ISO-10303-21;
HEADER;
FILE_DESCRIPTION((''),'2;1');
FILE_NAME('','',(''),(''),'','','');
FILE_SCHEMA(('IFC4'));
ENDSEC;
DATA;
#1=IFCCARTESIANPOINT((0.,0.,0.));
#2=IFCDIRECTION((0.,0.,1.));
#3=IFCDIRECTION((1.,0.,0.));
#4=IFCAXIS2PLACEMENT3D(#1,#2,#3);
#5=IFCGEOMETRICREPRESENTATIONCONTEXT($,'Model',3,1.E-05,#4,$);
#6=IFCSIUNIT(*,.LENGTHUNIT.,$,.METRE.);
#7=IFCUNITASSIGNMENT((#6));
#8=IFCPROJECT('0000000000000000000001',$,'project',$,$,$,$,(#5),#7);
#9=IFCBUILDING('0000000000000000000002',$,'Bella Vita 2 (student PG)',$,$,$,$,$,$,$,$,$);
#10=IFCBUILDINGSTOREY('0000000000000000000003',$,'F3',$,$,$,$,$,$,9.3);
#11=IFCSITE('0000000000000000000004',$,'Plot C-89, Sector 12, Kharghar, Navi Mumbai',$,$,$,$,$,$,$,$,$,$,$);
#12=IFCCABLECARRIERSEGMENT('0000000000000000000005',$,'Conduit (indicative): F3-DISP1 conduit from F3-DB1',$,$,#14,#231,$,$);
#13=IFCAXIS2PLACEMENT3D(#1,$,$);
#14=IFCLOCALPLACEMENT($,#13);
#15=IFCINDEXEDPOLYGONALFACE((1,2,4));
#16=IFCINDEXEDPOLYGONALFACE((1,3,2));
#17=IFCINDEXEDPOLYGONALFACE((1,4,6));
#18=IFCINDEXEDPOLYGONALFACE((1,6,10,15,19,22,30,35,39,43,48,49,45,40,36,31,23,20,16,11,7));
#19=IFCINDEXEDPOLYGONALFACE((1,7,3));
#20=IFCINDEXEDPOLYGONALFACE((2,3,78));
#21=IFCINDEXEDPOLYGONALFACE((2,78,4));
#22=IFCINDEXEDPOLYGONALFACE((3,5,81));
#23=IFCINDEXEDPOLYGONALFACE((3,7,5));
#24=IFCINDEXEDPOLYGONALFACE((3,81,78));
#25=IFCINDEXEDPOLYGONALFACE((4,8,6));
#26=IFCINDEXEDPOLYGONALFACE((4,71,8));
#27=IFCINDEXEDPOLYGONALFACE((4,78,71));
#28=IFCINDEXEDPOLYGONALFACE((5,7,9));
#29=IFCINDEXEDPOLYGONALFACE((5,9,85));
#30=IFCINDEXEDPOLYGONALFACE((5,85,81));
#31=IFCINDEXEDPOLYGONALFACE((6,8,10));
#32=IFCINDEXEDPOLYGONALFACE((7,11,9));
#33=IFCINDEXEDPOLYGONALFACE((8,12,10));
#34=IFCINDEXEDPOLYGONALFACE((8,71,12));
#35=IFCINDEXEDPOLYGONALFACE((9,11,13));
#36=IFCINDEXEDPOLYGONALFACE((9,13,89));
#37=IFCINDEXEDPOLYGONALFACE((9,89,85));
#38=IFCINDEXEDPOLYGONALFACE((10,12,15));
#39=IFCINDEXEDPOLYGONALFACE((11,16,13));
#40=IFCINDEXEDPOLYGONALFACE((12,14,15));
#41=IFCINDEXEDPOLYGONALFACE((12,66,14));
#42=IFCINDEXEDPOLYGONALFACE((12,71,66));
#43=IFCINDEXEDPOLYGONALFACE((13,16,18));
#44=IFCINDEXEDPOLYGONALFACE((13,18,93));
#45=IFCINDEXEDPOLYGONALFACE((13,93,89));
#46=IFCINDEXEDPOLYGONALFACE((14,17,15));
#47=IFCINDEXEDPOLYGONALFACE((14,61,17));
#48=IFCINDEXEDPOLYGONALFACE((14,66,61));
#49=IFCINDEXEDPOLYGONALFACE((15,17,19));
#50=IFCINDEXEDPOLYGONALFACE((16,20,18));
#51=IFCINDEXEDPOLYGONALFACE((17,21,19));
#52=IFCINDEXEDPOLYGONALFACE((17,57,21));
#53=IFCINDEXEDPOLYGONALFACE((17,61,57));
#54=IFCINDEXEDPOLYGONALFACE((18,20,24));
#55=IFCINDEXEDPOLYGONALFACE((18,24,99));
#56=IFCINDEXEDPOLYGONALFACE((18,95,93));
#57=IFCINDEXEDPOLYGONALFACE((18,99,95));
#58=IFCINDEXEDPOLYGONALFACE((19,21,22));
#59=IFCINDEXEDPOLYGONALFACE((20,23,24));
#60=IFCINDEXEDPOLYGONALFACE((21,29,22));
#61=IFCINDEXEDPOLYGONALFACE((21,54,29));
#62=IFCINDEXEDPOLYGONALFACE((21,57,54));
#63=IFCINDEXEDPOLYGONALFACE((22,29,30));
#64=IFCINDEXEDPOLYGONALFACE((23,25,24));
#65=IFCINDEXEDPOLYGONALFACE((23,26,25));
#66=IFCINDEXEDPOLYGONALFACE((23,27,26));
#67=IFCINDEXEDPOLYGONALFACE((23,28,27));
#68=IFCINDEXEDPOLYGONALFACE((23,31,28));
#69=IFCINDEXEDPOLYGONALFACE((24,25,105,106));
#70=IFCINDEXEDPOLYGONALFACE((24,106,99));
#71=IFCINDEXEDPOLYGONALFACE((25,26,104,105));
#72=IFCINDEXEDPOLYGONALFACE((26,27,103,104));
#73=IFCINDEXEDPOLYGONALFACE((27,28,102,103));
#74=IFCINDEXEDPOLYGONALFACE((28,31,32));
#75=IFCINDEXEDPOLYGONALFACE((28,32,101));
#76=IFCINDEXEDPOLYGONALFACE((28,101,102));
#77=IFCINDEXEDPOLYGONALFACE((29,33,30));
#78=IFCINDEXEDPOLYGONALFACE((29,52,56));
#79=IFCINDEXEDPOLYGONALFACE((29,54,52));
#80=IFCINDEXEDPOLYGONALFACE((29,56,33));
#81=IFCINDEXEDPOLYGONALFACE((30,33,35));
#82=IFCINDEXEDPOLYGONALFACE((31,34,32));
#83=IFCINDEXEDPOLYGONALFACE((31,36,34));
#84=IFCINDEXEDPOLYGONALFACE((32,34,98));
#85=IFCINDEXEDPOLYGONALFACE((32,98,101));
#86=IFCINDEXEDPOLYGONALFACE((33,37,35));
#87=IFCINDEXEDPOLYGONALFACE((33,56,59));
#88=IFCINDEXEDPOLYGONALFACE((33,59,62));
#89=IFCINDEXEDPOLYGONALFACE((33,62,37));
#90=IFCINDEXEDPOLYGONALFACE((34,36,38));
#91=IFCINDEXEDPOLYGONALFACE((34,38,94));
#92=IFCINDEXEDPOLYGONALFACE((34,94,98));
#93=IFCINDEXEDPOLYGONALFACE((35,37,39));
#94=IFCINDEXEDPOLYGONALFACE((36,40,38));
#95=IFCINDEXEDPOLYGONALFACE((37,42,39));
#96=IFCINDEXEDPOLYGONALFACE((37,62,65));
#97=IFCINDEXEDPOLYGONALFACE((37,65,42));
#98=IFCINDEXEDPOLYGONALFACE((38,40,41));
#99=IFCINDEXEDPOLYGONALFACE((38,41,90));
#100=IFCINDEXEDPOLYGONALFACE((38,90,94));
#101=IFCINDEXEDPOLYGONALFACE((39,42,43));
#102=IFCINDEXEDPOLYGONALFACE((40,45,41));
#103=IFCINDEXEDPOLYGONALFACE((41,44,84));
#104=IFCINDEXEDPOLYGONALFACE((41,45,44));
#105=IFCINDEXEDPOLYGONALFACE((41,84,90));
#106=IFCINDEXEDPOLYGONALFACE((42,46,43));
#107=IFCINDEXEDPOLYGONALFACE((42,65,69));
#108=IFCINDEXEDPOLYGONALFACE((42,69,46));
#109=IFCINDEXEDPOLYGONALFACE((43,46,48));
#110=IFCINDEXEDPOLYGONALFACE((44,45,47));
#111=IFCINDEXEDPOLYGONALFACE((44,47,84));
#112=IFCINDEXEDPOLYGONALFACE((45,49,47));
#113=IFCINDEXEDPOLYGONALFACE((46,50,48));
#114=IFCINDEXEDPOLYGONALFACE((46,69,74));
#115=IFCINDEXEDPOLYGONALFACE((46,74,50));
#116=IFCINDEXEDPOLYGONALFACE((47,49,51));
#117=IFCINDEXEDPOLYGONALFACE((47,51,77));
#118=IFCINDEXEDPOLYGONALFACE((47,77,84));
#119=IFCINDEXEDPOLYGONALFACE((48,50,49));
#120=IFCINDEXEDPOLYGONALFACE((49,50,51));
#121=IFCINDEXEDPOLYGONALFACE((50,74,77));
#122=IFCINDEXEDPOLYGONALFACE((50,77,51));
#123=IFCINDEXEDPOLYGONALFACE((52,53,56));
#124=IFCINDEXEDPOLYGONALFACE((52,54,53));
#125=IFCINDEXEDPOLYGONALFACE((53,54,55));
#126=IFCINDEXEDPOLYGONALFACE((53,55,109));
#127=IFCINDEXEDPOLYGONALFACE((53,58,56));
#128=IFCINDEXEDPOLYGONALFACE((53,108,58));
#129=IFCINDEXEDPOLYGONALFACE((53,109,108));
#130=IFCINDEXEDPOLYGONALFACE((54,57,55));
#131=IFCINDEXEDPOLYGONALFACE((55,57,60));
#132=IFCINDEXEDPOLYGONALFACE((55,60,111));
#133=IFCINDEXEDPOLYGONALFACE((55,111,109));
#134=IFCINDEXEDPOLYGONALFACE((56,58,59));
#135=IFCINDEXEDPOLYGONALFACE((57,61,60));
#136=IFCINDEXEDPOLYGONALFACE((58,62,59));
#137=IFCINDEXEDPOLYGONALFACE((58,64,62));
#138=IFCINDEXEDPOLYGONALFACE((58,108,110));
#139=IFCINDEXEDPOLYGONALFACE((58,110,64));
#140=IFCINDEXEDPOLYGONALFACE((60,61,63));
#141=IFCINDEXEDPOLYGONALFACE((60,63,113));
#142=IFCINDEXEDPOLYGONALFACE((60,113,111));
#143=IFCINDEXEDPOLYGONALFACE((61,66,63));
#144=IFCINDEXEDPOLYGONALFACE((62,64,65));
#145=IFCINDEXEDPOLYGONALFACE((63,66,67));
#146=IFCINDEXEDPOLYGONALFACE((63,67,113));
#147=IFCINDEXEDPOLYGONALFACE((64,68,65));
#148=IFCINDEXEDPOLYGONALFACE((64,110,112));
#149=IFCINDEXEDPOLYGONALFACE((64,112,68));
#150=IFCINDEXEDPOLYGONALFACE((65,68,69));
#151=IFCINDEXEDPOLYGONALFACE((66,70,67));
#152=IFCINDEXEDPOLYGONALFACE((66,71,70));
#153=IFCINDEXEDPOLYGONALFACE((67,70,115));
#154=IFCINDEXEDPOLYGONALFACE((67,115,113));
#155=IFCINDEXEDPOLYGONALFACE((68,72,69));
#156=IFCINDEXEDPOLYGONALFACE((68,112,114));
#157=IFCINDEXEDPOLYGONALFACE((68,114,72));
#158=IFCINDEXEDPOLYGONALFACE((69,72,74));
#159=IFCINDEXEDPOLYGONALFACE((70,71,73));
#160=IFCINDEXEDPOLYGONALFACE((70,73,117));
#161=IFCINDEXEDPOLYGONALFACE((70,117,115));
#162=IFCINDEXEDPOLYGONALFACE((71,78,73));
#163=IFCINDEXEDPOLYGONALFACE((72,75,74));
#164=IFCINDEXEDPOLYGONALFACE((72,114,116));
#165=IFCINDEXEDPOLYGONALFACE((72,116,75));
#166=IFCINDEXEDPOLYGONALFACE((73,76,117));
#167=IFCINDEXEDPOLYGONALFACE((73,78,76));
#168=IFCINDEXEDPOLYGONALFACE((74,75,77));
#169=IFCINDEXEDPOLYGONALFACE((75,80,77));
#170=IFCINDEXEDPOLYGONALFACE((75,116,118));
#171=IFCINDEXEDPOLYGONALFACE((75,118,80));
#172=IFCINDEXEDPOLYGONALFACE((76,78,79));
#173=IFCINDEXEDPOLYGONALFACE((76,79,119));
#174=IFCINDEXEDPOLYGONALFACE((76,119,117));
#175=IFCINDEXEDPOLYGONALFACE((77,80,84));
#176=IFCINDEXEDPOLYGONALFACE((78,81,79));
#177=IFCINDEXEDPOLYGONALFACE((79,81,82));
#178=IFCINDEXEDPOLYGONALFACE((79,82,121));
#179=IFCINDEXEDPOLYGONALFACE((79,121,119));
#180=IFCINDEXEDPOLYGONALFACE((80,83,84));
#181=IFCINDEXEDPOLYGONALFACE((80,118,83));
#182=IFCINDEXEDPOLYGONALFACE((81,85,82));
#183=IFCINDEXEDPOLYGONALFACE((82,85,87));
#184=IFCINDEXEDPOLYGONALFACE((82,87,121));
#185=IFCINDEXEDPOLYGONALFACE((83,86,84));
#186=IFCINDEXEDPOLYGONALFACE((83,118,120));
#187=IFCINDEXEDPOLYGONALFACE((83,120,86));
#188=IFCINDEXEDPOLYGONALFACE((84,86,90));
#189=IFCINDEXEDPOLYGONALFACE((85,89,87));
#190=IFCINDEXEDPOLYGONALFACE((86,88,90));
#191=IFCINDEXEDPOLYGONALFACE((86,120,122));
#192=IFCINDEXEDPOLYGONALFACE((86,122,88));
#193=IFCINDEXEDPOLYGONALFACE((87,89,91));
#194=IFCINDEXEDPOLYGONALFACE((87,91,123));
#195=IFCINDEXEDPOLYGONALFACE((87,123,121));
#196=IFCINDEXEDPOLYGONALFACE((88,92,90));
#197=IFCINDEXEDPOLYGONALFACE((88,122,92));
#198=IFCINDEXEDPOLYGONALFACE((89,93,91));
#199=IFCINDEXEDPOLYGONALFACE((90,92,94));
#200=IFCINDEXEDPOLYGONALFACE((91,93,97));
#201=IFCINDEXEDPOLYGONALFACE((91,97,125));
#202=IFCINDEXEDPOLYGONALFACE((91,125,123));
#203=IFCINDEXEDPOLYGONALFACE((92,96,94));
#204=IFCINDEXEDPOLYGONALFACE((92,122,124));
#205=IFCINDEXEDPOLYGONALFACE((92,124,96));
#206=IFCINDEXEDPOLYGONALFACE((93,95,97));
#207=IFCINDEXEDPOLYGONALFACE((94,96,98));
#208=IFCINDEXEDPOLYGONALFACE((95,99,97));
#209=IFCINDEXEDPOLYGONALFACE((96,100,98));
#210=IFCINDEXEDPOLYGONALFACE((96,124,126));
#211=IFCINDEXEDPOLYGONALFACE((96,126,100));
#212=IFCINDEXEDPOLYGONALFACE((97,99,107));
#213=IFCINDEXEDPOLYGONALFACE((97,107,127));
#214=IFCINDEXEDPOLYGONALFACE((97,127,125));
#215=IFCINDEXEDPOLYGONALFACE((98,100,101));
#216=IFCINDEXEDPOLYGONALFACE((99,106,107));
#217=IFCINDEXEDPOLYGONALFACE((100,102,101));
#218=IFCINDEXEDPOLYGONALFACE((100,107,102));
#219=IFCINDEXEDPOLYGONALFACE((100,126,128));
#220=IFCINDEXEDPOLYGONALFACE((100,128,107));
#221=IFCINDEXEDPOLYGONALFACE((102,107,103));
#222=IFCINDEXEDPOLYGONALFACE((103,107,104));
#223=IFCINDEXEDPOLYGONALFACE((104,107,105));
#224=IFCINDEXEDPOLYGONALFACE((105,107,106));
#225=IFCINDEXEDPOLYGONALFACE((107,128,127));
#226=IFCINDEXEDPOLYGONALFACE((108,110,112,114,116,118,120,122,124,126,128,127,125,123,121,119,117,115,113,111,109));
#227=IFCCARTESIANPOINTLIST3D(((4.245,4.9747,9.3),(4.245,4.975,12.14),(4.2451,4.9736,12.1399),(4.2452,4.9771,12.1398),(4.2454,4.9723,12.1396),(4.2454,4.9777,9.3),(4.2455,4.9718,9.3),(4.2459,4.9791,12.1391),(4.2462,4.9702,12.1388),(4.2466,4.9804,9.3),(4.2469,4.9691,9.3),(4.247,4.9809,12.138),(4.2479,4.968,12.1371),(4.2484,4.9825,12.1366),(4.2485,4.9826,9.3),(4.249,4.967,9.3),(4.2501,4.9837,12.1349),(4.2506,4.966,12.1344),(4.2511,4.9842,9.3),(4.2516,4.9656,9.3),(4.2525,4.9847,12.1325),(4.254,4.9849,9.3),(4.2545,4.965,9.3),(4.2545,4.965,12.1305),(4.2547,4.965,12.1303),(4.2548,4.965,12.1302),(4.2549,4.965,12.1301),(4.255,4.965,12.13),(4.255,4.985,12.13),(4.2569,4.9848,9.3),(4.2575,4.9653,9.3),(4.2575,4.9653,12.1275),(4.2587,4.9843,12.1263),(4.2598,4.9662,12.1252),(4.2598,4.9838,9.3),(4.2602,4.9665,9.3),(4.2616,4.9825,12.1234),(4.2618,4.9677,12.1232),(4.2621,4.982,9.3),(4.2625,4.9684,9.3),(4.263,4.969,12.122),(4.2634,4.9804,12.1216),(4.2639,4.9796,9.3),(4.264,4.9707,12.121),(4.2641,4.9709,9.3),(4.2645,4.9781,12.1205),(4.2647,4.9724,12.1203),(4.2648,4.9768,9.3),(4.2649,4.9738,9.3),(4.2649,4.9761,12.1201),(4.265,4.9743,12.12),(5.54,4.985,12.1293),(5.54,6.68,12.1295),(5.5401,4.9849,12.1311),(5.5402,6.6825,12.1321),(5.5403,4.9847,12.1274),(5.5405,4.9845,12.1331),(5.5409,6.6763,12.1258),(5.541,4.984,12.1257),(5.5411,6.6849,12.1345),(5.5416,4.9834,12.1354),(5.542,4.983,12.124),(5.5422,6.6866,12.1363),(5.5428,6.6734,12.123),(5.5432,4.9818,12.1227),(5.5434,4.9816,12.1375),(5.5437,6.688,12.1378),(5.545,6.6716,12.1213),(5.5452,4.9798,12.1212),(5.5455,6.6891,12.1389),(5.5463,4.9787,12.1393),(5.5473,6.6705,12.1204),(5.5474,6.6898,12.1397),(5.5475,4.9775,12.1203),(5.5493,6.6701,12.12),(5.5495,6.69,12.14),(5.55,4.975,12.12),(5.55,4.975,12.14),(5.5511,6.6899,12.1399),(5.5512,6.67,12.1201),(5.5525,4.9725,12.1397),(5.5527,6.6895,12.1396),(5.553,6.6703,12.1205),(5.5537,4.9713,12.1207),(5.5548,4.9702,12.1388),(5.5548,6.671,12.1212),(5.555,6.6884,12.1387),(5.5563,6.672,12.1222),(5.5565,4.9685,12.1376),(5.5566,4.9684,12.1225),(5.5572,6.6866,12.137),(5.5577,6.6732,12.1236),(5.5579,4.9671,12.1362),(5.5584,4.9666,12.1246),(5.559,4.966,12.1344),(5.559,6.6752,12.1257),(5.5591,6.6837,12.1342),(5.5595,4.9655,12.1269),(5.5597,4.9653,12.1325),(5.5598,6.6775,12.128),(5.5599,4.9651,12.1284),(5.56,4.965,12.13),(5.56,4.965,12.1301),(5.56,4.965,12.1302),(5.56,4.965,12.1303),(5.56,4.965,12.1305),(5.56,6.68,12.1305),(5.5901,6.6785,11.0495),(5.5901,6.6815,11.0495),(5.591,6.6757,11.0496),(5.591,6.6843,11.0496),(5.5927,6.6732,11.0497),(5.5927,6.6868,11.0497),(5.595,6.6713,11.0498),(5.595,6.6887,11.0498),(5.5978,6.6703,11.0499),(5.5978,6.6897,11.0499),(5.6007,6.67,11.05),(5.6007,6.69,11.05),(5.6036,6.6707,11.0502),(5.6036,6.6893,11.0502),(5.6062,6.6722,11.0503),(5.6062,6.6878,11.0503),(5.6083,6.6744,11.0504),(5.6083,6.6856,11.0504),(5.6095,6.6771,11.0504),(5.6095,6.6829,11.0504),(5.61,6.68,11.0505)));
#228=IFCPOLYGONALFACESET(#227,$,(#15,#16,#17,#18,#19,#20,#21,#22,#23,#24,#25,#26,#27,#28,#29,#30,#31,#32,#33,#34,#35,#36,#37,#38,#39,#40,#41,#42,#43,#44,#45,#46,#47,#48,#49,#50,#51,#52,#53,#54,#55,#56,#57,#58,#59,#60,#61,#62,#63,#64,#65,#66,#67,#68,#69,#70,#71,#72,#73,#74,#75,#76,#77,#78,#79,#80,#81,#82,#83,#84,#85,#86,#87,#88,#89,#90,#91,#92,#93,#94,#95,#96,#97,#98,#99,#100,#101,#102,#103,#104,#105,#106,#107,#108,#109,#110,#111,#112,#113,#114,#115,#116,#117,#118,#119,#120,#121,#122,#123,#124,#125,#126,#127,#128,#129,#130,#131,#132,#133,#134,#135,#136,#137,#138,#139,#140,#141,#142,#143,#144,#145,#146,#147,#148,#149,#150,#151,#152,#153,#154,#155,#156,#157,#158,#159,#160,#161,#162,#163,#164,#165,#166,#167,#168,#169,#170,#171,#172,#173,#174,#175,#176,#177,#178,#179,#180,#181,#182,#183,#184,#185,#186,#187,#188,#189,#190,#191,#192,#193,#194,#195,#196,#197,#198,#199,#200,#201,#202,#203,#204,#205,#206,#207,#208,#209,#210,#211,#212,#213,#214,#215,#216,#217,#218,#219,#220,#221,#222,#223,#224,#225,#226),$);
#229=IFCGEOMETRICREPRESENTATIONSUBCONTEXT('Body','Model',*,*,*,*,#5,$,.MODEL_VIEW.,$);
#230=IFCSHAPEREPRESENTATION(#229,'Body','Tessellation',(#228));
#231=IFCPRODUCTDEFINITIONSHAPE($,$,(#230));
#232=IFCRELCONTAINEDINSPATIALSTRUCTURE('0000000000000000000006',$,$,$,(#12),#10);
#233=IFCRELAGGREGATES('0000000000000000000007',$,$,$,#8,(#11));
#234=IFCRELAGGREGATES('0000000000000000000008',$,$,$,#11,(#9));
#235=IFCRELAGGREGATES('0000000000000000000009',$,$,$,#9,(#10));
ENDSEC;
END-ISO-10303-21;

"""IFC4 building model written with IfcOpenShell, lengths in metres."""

from ifc_helpers import new_model, entity, si_unit, origin, origin_with_axes, place, context, subcontext, project, spatial, element, save


model = new_model("IFC4")

# Units and contexts
model_context = context("Model", 3, precision=1e-05, world=origin_with_axes())
body_context = subcontext(model_context, "Body", "Model", "MODEL_VIEW")
ifc_project = project(units=[si_unit("LENGTHUNIT", "METRE")], contexts=[model_context])

# Site, building, storey
site = spatial("IfcSite", under=ifc_project, Name="Plot C-89, Sector 12, Kharghar, Navi Mumbai")
building = spatial("IfcBuilding", under=site, Name="Bella Vita 2 (student PG)")
storey = spatial("IfcBuildingStorey", under=building, Name="F3", Elevation=9.3)

# Cable carrier segment
cable_carrier_segment_1_placement = place(None, origin())
element("IfcCableCarrierSegment", 1, at=cable_carrier_segment_1_placement, inside=storey, Name="Conduit (indicative): F3-DISP1 conduit from F3-DB1", context=body_context, shape_type="AdvancedSweptSolid", body=[
    entity("IfcSweptDiskSolid", entity("IfcPolyline", [entity("IfcCartesianPoint", [5.6, 6.68, 11.05]), entity("IfcCartesianPoint", [5.55, 6.68, 12.13]), entity("IfcCartesianPoint", [5.55, 4.975, 12.13]), entity("IfcCartesianPoint", [4.255, 4.975, 12.13]), entity("IfcCartesianPoint", [4.255, 4.975, 9.3])]), 0.01),
])

save(model, "model.ifc")
